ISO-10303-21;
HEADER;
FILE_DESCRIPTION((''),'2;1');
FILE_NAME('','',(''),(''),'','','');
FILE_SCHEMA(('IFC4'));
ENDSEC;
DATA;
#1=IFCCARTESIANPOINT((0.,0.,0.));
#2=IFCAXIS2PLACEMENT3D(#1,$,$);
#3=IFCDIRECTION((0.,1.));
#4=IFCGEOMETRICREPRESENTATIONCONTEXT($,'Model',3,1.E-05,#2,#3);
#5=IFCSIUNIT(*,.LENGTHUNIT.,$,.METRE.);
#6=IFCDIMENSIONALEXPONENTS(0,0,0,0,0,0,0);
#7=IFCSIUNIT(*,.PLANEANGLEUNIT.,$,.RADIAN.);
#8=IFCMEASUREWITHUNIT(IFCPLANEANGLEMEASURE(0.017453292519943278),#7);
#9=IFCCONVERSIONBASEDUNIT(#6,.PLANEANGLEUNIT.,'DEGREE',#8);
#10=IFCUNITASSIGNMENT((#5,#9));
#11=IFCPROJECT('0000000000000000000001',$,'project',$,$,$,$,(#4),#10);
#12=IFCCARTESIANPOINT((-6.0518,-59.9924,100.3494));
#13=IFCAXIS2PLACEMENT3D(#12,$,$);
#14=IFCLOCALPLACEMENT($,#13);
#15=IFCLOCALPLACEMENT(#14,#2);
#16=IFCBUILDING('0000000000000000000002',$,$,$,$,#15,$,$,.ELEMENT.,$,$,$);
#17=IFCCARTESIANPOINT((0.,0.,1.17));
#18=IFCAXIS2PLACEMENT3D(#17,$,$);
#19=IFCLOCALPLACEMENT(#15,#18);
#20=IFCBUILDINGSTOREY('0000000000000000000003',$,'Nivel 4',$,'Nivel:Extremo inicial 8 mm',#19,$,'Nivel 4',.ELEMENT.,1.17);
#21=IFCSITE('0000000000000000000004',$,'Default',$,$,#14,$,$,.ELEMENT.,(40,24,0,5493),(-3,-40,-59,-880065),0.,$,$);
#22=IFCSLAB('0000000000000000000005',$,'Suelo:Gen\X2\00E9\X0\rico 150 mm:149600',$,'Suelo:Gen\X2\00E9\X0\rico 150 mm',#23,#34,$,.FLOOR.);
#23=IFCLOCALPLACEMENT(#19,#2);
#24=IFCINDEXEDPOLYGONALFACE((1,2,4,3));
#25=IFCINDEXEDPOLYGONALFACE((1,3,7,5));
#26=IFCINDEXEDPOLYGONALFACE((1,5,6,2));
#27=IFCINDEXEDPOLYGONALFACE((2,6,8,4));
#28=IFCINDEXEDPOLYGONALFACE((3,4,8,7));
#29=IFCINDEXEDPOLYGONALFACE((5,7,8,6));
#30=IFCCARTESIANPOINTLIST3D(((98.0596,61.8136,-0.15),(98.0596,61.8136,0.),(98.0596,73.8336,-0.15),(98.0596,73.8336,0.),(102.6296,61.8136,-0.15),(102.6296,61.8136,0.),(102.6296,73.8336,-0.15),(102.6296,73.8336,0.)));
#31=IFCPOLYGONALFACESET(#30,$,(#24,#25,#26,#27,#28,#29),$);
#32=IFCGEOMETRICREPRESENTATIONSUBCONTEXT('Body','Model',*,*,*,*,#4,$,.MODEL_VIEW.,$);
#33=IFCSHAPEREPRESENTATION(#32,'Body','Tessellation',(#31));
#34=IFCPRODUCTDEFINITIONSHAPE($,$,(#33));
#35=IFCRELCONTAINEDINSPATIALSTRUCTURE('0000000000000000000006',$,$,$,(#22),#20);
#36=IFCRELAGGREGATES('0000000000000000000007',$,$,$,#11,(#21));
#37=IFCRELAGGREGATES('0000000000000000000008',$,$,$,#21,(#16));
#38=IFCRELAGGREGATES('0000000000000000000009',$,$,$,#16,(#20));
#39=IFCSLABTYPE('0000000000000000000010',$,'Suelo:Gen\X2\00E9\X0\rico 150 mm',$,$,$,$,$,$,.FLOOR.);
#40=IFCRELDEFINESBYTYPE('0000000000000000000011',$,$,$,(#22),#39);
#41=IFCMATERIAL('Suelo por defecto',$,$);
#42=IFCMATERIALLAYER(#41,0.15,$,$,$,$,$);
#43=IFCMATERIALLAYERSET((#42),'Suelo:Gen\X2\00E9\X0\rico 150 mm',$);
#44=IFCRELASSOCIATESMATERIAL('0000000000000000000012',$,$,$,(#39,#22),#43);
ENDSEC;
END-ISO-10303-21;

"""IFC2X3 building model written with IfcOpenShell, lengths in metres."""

from ifc_helpers import new_model, entity, si_unit, converted_unit, direction, frame, frame_2d, origin, place, context, subcontext, project, spatial, rectangle, extrude, material, layer, layer_set, layer_usage, type_object, element, save


model = new_model("IFC2X3")

# Units and contexts
model_context = context("Model", 3, precision=1e-05, world=origin(), true_north=direction((0.0, 1.0)))
body_context = subcontext(model_context, "Body", "Model", "MODEL_VIEW")
ifc_project = project(units=[si_unit("LENGTHUNIT", "METRE"), converted_unit("PLANEANGLEUNIT", "DEGREE", entity("IfcPlaneAngleMeasure", 0.017453292519943278), si_unit("PLANEANGLEUNIT", "RADIAN"), dimensions=[0, 0, 0, 0, 0, 0, 0])], contexts=[model_context])

# Site, building, storey
site_placement = place(None, frame((-6.0518, -59.9924, 100.3494)))
site = spatial("IfcSite", under=ifc_project, at=site_placement, Name="Default", CompositionType="ELEMENT", RefLatitude=(40, 24, 0, 5493), RefLongitude=(-3, -40, -59, -880065), RefElevation=0.0)
building_placement = place(site_placement, origin())
building = spatial("IfcBuilding", under=site, at=building_placement, CompositionType="ELEMENT")
storey_placement = place(building_placement, frame((0.0, 0.0, 1.17)))
storey = spatial("IfcBuildingStorey", under=building, at=storey_placement, Name="Nivel 4", ObjectType="Nivel:Extremo inicial 8 mm", LongName="Nivel 4", CompositionType="ELEMENT", Elevation=1.17)

# Slab
ifc_material_1 = material(Name="Suelo por defecto")
ifc_layer = layer(ifc_material_1, 0.15)
ifc_layer_set = layer_set([ifc_layer], Name="Suelo:Genérico 150 mm")
ifc_layer_usage = layer_usage(ifc_layer_set, "AXIS3", "POSITIVE", 0.0)
slab_type = type_object("IfcSlabType", Name="Suelo:Genérico 150 mm", PredefinedType="FLOOR", material=ifc_layer_set)
slab_placement = place(storey_placement, origin())
element("IfcSlab", 1, at=slab_placement, inside=storey, type_object=slab_type, material=ifc_layer_usage, Name="Suelo:Genérico 150 mm:149600", ObjectType="Suelo:Genérico 150 mm", PredefinedType="FLOOR", context=body_context, shape_type="SweptSolid", body=[
    extrude(rectangle(XDim=12.02, YDim=4.57, at=frame_2d((0.0, 0.0), x_axis=(1.0, 0.0))), frame((100.3446, 67.8236, 0.0), z_axis=(0.0, 0.0, -1.0), x_axis=(0.0, 1.0, 0.0)), (0.0, 0.0, 1.0), 0.15),
])

save(model, "model.ifc")
